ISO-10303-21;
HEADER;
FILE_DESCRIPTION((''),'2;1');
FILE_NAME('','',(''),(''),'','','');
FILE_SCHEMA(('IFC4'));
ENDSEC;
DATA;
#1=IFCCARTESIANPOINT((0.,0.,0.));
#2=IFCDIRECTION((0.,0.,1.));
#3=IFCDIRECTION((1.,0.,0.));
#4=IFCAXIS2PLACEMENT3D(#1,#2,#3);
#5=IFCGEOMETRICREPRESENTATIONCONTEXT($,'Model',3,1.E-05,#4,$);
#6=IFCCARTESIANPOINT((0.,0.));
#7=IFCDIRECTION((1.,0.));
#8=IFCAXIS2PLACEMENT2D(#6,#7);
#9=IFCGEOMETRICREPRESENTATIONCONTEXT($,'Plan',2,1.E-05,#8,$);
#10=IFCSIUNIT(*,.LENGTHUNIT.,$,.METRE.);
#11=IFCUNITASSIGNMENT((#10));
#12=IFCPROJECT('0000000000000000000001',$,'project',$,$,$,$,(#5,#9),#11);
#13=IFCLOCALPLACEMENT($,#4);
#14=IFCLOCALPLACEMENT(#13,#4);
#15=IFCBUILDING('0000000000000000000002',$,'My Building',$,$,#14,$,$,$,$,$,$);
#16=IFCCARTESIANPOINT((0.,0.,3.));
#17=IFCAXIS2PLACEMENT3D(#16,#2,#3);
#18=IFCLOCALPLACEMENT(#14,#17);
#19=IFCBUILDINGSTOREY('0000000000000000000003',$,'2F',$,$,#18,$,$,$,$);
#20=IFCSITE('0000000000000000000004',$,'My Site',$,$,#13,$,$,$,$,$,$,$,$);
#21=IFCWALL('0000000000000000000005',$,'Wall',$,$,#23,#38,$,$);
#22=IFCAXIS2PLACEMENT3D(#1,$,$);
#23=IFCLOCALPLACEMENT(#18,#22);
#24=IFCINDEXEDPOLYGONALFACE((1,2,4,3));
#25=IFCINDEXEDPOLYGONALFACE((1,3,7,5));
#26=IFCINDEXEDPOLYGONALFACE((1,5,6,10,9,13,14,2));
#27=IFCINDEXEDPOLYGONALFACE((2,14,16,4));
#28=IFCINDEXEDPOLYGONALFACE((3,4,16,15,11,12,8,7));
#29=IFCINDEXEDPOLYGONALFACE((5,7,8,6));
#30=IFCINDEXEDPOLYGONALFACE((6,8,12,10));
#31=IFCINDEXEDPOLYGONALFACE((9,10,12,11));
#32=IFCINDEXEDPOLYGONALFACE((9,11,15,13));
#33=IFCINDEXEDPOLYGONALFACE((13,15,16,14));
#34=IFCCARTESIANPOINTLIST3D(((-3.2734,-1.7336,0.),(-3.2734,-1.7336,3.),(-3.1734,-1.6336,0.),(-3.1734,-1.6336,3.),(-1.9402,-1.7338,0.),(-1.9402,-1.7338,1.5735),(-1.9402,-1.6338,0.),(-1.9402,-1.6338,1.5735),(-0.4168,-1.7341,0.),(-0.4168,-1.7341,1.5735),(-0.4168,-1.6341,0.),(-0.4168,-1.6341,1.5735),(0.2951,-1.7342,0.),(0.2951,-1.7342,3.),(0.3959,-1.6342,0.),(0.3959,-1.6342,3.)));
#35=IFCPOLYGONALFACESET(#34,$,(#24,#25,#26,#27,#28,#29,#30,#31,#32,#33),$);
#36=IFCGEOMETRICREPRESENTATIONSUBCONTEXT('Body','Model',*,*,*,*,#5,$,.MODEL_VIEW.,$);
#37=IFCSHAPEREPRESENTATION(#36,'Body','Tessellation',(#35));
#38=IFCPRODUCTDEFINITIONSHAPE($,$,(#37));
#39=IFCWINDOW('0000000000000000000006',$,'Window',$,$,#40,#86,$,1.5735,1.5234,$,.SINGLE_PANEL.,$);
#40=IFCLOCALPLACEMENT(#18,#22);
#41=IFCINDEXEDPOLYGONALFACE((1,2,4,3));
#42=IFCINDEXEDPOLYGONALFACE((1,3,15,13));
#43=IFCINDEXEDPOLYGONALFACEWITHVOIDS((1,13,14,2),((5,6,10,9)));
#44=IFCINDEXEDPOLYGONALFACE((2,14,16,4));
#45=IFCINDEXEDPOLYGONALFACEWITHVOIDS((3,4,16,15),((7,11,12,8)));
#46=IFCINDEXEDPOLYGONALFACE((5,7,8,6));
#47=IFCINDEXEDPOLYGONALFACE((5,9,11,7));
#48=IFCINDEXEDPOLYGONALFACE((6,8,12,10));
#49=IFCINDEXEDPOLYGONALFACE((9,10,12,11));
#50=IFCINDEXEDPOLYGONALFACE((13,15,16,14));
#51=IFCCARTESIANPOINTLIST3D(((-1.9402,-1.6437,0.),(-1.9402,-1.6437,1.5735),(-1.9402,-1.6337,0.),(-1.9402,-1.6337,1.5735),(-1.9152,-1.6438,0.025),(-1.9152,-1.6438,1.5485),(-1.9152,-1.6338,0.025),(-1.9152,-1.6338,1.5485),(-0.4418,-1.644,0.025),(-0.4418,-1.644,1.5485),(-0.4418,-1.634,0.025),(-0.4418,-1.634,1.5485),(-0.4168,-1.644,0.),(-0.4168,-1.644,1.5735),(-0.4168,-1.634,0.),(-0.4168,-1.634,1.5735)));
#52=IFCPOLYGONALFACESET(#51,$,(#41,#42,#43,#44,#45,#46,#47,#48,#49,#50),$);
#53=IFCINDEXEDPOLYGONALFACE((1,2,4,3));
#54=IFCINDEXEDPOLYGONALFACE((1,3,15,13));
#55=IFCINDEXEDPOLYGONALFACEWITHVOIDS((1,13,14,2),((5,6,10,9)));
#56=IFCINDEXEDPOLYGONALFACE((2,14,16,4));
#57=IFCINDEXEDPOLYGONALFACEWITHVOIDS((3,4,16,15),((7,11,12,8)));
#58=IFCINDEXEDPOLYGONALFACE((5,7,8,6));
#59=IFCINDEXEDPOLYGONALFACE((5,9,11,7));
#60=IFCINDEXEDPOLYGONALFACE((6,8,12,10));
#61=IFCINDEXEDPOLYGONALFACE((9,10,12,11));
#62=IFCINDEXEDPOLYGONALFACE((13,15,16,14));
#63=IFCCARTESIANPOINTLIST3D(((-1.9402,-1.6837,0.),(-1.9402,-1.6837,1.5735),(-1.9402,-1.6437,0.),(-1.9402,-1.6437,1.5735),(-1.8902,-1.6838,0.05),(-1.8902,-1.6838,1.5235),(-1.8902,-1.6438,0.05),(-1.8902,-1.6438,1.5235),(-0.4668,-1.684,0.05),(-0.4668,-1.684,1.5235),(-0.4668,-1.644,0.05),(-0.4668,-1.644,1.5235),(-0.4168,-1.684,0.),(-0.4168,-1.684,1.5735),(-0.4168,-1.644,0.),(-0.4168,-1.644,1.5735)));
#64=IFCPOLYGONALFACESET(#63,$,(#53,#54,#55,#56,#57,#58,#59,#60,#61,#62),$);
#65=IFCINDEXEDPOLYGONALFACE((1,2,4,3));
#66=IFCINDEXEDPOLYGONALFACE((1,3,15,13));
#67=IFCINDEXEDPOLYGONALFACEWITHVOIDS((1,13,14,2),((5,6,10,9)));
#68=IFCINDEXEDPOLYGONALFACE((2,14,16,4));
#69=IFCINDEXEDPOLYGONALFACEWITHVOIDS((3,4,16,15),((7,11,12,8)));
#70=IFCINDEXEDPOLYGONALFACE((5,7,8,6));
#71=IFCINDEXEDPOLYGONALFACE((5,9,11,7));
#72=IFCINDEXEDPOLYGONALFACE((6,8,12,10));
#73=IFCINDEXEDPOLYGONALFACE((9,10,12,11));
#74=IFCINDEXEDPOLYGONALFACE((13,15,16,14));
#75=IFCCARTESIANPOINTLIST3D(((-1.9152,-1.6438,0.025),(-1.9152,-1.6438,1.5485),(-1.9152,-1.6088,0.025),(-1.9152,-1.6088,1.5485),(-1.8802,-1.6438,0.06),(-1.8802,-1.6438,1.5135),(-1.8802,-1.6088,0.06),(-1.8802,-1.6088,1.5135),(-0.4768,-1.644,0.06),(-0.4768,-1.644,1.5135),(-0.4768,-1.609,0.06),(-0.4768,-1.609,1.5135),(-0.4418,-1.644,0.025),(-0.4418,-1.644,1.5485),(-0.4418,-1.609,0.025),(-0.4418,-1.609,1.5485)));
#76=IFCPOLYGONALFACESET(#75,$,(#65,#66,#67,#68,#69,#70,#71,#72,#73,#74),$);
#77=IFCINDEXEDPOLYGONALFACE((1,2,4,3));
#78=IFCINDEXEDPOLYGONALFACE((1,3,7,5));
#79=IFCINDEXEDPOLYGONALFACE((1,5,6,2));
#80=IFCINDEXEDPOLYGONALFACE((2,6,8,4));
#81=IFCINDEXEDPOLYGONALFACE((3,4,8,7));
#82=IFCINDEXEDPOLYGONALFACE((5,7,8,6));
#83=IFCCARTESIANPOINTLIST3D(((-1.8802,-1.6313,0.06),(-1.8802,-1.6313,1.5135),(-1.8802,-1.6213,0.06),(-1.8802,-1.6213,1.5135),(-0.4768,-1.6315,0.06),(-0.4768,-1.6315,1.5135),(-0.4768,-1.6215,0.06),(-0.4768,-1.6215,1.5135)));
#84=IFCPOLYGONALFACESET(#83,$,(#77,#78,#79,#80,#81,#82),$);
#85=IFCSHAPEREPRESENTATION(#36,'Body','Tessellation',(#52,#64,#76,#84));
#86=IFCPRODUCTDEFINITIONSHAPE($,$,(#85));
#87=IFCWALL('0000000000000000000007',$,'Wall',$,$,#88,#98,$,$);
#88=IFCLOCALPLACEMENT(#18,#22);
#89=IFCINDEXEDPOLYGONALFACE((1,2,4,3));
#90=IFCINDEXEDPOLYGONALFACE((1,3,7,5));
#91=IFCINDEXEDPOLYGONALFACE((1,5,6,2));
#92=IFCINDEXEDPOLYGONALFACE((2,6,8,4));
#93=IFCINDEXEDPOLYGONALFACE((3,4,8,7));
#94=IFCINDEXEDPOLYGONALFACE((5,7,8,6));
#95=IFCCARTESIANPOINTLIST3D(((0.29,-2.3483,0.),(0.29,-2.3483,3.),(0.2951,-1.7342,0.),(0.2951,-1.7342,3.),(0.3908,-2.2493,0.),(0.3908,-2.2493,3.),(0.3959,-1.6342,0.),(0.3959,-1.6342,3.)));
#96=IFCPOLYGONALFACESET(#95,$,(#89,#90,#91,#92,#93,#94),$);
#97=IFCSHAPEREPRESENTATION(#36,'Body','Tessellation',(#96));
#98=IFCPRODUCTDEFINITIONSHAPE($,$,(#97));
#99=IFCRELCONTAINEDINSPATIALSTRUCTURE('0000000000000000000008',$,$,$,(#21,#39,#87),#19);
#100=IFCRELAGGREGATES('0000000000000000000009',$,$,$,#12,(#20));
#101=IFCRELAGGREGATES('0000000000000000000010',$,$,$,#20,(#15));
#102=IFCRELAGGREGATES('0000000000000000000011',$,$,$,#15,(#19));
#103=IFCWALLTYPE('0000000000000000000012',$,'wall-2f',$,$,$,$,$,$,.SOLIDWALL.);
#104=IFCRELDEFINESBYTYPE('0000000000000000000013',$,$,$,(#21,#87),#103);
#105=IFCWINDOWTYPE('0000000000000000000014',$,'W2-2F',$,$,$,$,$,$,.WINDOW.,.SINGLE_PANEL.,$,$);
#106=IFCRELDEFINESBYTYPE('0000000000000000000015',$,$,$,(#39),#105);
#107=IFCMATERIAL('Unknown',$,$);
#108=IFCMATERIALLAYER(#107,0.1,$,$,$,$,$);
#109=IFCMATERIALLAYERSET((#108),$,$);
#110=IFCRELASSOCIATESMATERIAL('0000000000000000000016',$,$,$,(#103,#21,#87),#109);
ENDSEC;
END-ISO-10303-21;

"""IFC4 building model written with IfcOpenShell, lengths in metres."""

from ifc_helpers import new_model, entity, si_unit, frame, origin_with_axes, origin_2d_with_axis, place, context, subcontext, project, spatial, line, indexed_curve, outline, extrude, shape, source, transform, mapped, material, layer, layer_set, layer_usage, type_object, type_shapes, element, fill, save


model = new_model("IFC4")

# Units and contexts
model_context = context("Model", 3, precision=1e-05, world=origin_with_axes())
plan_context = context("Plan", 2, precision=1e-05, world=origin_2d_with_axis())
body_context_1 = subcontext(model_context, "Body", "Model", "MODEL_VIEW")
body_context_2 = subcontext(plan_context, "Body", "Plan", "PLAN_VIEW")
ifc_project = project(units=[si_unit("LENGTHUNIT", "METRE")], contexts=[model_context, plan_context])

# Site, building, storey
site_placement = place(None, origin_with_axes())
site = spatial("IfcSite", under=ifc_project, at=site_placement, Name="My Site")
building_placement = place(site_placement, origin_with_axes())
building = spatial("IfcBuilding", under=site, at=building_placement, Name="My Building")
storey_placement = place(building_placement, frame((0.0, 0.0, 3.0), z_axis=(0.0, 0.0, 1.0), x_axis=(1.0, 0.0, 0.0)))
storey = spatial("IfcBuildingStorey", under=building, at=storey_placement, Name="2F")

# Wall, opening, window
ifc_material = material(Name="Unknown")
ifc_layer_1 = layer(ifc_material, 0.1)
ifc_layer_set_1 = layer_set([ifc_layer_1])
ifc_layer_usage_1 = layer_usage(ifc_layer_set_1, "AXIS2", "POSITIVE", 0.0)
wall_type_1 = type_object("IfcWallType", Name="wall-2f", PredefinedType="SOLIDWALL", material=ifc_layer_set_1)
wall_1_placement = place(storey_placement, frame((-3.2734, -1.7336, 0.0), z_axis=(0.0, 0.0, 1.0), x_axis=(1.0, -0.000162, 0.0)))
wall_1 = element("IfcWall", 1, at=wall_1_placement, inside=storey, type_object=wall_type_1, material=ifc_layer_usage_1, Name="Wall", context=body_context_1, shape_type="SweptSolid", body=[
    extrude(outline(indexed_curve([(0.0, 0.0), (0.1, 0.1), (3.6693, 0.1), (3.5685, 0.0)], segments=[line(1, 2, 3, 4, 1)])), origin_with_axes(), (0.0, 0.0, 1.0), 3.0),
])
shared_shape_1 = source(origin_with_axes(), body_context_1, "Body", "SweptSolid", [
    extrude(outline(indexed_curve([(0.0, 0.0), (1.5234, 0.0), (1.5234, 1.5735), (0.0, 1.5735)], segments=[line(1, 2, 3, 4, 1)])), frame((0.0, -0.6, 0.0), z_axis=(0.0, -1.0, 0.0), x_axis=(1.0, 0.0, 0.0)), (0.0, 0.0, -1.0), 1.2),
])
opening_1_placement = place(wall_1_placement, frame((1.3332, 0.0001, 0.0), z_axis=(0.0, 0.0, 1.0), x_axis=(1.0, 0.0, 0.0)))
opening_1 = element("IfcOpeningElement", 2, at=opening_1_placement, cuts=wall_1, PredefinedType="OPENING", context=body_context_1, shape_type="MappedRepresentation", body=[
    mapped(shared_shape_1, transform((0.0, 0.0, 0.0), x_axis=(1.0, 0.0, 0.0), y_axis=(0.0, 1.0, 0.0), z_axis=(0.0, 0.0, 1.0), scale=1.0)),
])
window_type_1 = type_object("IfcWindowType", Name="W2-2F", PartitioningType="SINGLE_PANEL", PredefinedType="WINDOW")
shared_shape_2 = source(origin_with_axes(), body_context_1, "Body", "SweptSolid", [
    extrude(outline(indexed_curve([(0.0, 0.0), (1.5234, 0.0), (1.5234, 1.5735), (0.0, 1.5735)], segments=[line(1, 2, 3, 4, 1)]), holes=[indexed_curve([(0.025, 0.025), (1.4984, 0.025), (1.4984, 1.5485), (0.025, 1.5485)], segments=[line(1, 2, 3, 4, 1)])]), frame((0.0, 0.09, 0.0), z_axis=(0.0, -1.0, 0.0), x_axis=(1.0, 0.0, 0.0)), (0.0, 0.0, -1.0), 0.01),
    extrude(outline(indexed_curve([(0.0, 0.0), (1.5234, 0.0), (1.5234, 1.5735), (0.0, 1.5735)], segments=[line(1, 2, 3, 4, 1)]), holes=[indexed_curve([(0.05, 0.05), (1.4734, 0.05), (1.4734, 1.5235), (0.05, 1.5235)], segments=[line(1, 2, 3, 4, 1)])]), frame((0.0, 0.05, 0.0), z_axis=(0.0, -1.0, 0.0), x_axis=(1.0, 0.0, 0.0)), (0.0, 0.0, -1.0), 0.04),
    extrude(outline(indexed_curve([(0.0, 0.0), (1.4734, 0.0), (1.4734, 1.5235), (0.0, 1.5235)], segments=[line(1, 2, 3, 4, 1)]), holes=[indexed_curve([(0.035, 0.035), (1.4384, 0.035), (1.4384, 1.4885), (0.035, 1.4885)], segments=[line(1, 2, 3, 4, 1)])]), frame((0.025, 0.09, 0.025), z_axis=(0.0, -1.0, 0.0), x_axis=(1.0, 0.0, 0.0)), (0.0, 0.0, -1.0), 0.035),
    extrude(outline(indexed_curve([(0.035, 0.035), (1.4384, 0.035), (1.4384, 1.4885), (0.035, 1.4885)], segments=[line(1, 2, 3, 4, 1)])), frame((0.025, 0.1025, 0.025), z_axis=(0.0, -1.0, 0.0), x_axis=(1.0, 0.0, 0.0)), (0.0, 0.0, -1.0), 0.01),
])
shared_shape_3 = source(origin_with_axes(), body_context_2, "Body", "Curve2D", [
    entity("IfcIndexedPolyCurve", entity("IfcCartesianPointList2D", [[0.05, 0.05], [1.4734, 0.05]])),
    entity("IfcIndexedPolyCurve", entity("IfcCartesianPointList2D", [[0.0, 0.1], [0.025, 0.1], [0.025, 0.09], [0.05, 0.09], [0.05, 0.05], [0.0, 0.05]]), [entity("IfcLineIndex", [1, 2, 3, 4, 5, 6, 1])]),
    entity("IfcIndexedPolyCurve", entity("IfcCartesianPointList2D", [[1.5234, 0.1], [1.4984, 0.1], [1.4984, 0.09], [1.4734, 0.09], [1.4734, 0.05], [1.5234, 0.05]]), [entity("IfcLineIndex", [1, 2, 3, 4, 5, 6, 1])]),
    entity("IfcIndexedPolyCurve", entity("IfcCartesianPointList2D", [[0.025, 0.09], [0.06, 0.09], [0.06, 0.125], [0.025, 0.125]]), [entity("IfcLineIndex", [1, 2, 3, 4, 1])]),
    entity("IfcIndexedPolyCurve", entity("IfcCartesianPointList2D", [[1.4984, 0.09], [1.4634, 0.09], [1.4634, 0.125], [1.4984, 0.125]]), [entity("IfcLineIndex", [1, 2, 3, 4, 1])]),
    entity("IfcIndexedPolyCurve", entity("IfcCartesianPointList2D", [[0.06, 0.09], [1.4634, 0.09]])),
    entity("IfcIndexedPolyCurve", entity("IfcCartesianPointList2D", [[0.06, 0.125], [1.4634, 0.125]])),
    entity("IfcIndexedPolyCurve", entity("IfcCartesianPointList2D", [[0.06, 0.1075], [1.4634, 0.1075]])),
])
type_shapes(window_type_1, [shared_shape_2, shared_shape_3])
window_1_placement = place(opening_1_placement, frame((0.0, 0.0, 0.0), z_axis=(0.0, 0.0, 1.0), x_axis=(1.0, 0.0, 0.0)))
window_1 = element("IfcWindow", 3, at=window_1_placement, inside=storey, type_object=window_type_1, Name="Window", OverallHeight=1.5735, OverallWidth=1.5234, PartitioningType="SINGLE_PANEL", shapes=[
    shape(body_context_1, "Body", "MappedRepresentation", [mapped(shared_shape_2, transform((0.0, 0.0, 0.0), x_axis=(1.0, 0.0, 0.0), y_axis=(0.0, 1.0, 0.0), z_axis=(0.0, 0.0, 1.0), scale=1.0))]),
    shape(body_context_2, "Body", "MappedRepresentation", [mapped(shared_shape_3, transform((0.0, 0.0, 0.0), x_axis=(1.0, 0.0, 0.0), y_axis=(0.0, 1.0, 0.0), z_axis=(0.0, 0.0, 1.0), scale=1.0))]),
])
fill(opening_1, window_1)

# Wall
ifc_layer_usage_2 = layer_usage(ifc_layer_set_1, "AXIS2", "POSITIVE", 0.0)
wall_2_placement = place(storey_placement, frame((0.2951, -1.7342, 0.0), z_axis=(0.0, 0.0, 1.0), x_axis=(-0.008316, -0.999965, 0.0)))
element("IfcWall", 4, at=wall_2_placement, inside=storey, type_object=wall_type_1, material=ifc_layer_usage_2, Name="Wall", context=body_context_1, shape_type="SweptSolid", body=[
    extrude(outline(indexed_curve([(0.0, 0.0), (-0.1008, 0.1), (0.5142, 0.1), (0.6141, 0.0)], segments=[line(1, 2, 3, 4, 1)])), origin_with_axes(), (0.0, 0.0, 1.0), 3.0),
])

save(model, "model.ifc")
